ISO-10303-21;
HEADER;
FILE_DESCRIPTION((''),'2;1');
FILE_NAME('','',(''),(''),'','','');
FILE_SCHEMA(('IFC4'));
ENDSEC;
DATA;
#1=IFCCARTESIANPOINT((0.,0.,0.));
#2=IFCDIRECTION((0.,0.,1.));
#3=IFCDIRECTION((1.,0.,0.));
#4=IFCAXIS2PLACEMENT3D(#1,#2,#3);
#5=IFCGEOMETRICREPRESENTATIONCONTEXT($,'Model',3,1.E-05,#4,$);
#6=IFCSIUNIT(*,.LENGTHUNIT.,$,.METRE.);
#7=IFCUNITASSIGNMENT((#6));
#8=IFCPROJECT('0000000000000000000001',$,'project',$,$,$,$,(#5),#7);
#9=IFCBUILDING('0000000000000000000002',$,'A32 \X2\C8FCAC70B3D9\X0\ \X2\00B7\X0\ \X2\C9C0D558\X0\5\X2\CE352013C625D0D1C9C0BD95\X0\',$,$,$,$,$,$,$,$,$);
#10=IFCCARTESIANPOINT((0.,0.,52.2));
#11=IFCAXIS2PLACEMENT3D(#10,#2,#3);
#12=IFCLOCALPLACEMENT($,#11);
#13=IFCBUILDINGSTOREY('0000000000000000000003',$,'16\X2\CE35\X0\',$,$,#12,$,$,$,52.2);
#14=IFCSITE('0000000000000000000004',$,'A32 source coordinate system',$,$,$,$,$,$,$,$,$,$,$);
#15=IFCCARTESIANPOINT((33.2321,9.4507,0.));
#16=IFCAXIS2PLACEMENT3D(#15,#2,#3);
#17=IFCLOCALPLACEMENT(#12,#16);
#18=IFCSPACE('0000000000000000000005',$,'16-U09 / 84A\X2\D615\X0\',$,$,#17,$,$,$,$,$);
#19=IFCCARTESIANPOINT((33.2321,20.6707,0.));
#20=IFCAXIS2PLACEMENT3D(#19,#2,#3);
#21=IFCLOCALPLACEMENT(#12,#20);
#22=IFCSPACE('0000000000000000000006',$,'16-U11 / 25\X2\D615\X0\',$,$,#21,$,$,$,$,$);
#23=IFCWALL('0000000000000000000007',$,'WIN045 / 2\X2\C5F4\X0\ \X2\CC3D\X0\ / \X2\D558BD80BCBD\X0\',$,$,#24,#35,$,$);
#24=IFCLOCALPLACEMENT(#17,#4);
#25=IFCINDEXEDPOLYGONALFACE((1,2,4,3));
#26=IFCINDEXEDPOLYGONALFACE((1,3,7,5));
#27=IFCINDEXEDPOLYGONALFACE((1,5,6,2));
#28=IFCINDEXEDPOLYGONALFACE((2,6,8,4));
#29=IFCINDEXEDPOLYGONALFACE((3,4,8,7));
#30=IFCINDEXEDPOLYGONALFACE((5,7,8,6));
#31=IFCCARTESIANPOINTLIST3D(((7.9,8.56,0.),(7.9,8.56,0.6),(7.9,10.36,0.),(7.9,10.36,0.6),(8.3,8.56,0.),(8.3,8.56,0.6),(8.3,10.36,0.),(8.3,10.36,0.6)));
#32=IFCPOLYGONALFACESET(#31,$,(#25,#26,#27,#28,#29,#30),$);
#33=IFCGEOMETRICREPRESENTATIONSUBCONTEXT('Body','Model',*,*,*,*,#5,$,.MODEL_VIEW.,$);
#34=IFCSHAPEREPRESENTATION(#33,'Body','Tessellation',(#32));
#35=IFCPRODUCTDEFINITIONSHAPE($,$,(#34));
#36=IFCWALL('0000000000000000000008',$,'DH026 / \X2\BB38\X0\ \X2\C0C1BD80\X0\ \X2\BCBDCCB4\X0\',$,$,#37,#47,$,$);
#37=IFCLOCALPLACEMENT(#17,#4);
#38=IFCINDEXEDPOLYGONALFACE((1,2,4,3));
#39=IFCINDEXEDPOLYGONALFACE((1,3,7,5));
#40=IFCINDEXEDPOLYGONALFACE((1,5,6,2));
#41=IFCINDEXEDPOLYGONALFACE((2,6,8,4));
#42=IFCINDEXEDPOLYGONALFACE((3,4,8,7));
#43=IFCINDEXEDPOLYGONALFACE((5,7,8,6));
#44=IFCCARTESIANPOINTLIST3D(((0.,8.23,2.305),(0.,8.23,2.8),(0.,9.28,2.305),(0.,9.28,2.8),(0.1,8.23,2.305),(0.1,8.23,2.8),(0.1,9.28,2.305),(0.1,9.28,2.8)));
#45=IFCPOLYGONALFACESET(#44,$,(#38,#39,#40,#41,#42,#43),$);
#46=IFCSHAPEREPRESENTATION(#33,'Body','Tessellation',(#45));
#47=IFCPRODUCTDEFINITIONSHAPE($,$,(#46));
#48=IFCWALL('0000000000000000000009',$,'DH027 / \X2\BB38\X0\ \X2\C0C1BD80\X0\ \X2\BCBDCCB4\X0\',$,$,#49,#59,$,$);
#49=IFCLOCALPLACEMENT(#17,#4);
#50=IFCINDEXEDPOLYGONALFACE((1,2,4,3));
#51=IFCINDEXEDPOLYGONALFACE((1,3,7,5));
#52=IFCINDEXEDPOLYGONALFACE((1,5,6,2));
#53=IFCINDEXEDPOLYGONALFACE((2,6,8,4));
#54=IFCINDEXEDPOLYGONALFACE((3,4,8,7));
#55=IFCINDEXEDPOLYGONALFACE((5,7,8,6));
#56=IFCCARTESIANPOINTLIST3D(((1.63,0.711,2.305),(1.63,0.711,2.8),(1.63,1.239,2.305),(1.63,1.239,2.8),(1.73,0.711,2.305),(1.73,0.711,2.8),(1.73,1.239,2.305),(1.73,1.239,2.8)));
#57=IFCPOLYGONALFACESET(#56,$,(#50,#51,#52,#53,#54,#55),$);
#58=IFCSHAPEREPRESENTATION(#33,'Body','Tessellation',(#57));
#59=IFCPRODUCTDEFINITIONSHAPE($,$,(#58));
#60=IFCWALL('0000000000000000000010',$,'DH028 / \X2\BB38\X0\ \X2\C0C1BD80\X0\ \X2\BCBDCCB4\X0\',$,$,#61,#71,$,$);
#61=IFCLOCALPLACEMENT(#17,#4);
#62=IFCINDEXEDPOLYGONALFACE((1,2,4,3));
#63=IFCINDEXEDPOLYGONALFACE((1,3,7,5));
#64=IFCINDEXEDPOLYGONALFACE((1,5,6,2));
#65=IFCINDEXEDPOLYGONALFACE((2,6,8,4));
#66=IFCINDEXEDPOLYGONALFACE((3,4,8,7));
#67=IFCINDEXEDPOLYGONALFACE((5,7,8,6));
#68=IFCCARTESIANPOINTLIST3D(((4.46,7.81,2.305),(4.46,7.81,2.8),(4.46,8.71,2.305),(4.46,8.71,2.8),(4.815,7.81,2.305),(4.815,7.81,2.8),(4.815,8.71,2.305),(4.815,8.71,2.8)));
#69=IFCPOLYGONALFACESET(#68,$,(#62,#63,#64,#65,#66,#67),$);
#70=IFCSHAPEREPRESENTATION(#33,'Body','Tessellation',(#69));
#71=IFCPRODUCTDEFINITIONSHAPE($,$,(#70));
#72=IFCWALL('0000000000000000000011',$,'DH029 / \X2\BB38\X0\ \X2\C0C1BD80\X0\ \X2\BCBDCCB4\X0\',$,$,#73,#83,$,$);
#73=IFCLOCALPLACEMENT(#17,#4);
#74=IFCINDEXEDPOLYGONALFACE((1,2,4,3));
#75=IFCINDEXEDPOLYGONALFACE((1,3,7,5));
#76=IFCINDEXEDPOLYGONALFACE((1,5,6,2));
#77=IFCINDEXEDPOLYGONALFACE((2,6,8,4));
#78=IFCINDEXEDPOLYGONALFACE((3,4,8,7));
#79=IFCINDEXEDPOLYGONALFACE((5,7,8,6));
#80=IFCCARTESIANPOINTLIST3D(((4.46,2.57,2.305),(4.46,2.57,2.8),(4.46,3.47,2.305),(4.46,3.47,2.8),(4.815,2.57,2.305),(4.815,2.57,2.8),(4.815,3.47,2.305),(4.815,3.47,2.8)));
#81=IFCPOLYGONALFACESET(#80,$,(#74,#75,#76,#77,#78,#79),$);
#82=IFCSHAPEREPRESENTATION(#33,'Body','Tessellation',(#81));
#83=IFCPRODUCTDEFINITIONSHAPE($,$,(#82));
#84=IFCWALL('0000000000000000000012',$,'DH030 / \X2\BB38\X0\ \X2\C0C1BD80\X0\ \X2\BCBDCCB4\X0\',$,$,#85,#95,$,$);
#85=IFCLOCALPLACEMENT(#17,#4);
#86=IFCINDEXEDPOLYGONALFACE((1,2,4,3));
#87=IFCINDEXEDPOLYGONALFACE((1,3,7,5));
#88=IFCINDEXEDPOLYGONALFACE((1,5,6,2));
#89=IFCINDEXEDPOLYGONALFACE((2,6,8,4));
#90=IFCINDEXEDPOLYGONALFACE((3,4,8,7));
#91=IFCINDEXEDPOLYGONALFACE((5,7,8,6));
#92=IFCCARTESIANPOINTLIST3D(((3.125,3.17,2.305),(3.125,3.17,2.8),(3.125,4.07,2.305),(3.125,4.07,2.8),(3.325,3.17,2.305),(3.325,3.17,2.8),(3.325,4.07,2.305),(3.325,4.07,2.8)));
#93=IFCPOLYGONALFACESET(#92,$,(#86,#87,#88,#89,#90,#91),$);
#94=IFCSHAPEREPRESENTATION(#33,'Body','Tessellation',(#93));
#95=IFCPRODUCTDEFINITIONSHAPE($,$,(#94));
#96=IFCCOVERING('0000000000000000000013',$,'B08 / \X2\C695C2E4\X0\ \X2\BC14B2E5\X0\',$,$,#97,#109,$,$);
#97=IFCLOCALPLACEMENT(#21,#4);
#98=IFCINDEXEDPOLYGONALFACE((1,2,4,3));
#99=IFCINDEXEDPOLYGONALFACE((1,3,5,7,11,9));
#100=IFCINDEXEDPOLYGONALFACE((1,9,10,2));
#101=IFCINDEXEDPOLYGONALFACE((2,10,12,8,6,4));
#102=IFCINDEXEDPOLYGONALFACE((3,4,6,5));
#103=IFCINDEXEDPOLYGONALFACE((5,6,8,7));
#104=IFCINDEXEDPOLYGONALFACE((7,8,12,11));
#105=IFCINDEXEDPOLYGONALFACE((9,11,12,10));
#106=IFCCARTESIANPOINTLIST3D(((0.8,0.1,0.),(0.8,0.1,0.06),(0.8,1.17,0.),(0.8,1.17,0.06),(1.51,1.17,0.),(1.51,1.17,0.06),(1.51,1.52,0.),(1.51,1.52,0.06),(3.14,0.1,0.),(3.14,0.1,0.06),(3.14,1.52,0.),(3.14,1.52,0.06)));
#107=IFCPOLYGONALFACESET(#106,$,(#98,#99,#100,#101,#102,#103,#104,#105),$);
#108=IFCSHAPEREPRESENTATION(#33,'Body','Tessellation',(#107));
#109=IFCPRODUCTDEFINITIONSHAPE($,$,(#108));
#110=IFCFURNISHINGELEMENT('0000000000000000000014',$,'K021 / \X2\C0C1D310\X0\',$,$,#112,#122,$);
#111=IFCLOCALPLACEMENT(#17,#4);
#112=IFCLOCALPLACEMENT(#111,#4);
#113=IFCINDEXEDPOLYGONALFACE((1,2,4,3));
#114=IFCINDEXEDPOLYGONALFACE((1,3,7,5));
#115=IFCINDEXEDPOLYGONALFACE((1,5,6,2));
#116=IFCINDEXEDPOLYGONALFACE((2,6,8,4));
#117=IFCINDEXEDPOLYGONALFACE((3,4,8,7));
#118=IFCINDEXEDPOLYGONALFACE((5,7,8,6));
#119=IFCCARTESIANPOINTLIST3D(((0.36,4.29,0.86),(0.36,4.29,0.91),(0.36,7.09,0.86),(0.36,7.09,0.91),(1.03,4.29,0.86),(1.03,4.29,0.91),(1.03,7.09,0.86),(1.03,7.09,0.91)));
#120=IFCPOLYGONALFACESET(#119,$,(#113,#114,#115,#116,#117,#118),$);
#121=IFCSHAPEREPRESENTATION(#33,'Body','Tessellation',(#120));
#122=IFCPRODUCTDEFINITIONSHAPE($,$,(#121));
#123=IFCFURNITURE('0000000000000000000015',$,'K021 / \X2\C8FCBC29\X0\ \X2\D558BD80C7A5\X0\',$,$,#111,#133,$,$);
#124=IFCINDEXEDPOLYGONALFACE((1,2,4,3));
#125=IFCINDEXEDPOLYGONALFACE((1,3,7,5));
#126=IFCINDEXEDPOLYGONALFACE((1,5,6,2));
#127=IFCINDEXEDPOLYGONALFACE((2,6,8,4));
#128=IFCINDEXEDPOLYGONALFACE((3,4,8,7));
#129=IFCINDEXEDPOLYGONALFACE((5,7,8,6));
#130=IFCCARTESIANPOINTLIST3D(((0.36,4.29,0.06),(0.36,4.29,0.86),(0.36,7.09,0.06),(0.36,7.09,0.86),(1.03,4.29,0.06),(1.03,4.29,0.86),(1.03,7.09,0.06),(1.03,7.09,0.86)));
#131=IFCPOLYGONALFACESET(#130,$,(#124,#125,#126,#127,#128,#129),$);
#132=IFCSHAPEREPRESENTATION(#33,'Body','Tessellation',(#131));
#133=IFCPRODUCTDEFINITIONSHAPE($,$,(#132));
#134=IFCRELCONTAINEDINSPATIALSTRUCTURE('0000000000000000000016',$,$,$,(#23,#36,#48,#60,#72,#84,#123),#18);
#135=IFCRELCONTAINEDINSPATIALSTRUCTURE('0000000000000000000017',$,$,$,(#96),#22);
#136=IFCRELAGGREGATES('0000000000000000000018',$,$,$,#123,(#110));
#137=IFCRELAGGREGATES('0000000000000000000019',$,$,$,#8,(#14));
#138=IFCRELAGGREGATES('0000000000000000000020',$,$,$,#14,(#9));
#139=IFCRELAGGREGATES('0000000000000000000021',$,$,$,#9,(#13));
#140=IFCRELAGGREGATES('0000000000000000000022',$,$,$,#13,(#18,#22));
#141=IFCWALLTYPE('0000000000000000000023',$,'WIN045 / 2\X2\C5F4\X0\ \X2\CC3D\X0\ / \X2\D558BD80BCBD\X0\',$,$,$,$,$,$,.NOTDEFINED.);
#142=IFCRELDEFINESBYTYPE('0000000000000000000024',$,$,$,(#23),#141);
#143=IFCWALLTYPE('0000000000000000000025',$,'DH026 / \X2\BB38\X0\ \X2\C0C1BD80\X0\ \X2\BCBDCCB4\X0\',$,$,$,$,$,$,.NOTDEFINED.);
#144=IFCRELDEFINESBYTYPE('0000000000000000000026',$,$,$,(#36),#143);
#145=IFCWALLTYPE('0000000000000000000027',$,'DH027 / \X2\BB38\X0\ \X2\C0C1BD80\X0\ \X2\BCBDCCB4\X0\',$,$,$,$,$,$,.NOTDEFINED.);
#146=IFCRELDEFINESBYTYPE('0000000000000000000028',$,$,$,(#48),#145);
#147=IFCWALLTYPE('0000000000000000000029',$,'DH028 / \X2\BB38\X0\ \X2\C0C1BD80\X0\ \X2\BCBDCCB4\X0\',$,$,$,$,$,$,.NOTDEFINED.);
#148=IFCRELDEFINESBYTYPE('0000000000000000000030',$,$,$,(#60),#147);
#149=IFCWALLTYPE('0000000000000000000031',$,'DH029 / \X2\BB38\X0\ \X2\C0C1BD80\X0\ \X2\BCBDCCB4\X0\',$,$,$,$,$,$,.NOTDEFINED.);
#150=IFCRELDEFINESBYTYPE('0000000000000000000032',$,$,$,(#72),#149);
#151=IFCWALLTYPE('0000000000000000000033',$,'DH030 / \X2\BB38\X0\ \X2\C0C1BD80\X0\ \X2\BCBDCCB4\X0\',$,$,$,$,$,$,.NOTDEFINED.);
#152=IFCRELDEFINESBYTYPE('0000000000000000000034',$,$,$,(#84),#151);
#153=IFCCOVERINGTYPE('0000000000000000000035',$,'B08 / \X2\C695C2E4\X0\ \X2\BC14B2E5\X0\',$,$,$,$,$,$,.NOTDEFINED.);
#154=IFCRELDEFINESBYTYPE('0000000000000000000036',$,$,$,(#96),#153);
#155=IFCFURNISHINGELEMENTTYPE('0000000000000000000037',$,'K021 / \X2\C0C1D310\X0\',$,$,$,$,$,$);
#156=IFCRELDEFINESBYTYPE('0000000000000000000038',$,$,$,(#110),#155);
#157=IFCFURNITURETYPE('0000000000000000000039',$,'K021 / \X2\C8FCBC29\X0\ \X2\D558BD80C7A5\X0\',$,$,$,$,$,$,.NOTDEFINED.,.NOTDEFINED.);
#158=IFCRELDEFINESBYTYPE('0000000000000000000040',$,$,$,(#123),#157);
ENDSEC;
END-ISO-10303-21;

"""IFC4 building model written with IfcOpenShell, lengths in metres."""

from ifc_helpers import new_model, si_unit, frame, origin, origin_with_axes, place, context, subcontext, project, spatial, polyline, outline, extrude, source, transform, mapped, type_object, type_shapes, element, aggregate, save


model = new_model("IFC4")

# Units and contexts
model_context = context("Model", 3, precision=1e-05, world=origin_with_axes())
body_context = subcontext(model_context, "Body", "Model", "MODEL_VIEW")
ifc_project = project(units=[si_unit("LENGTHUNIT", "METRE")], contexts=[model_context])

# Site, building, storey, space
site = spatial("IfcSite", under=ifc_project, Name="A32 source coordinate system")
building = spatial("IfcBuilding", under=site, Name="A32 주거동 · 지하5층–옥탑지붕")
storey_placement = place(None, frame((0.0, 0.0, 52.2), z_axis=(0.0, 0.0, 1.0), x_axis=(1.0, 0.0, 0.0)))
storey = spatial("IfcBuildingStorey", under=building, at=storey_placement, Name="16층", Elevation=52.2)
space_1_placement = place(storey_placement, frame((33.2321, 9.4507, 0.0), z_axis=(0.0, 0.0, 1.0), x_axis=(1.0, 0.0, 0.0)))
space_1 = spatial("IfcSpace", under=storey, at=space_1_placement, Name="16-U09 / 84A형")

# Walls
wall_type_1 = type_object("IfcWallType", Name="WIN045 / 2열 창 / 하부벽", PredefinedType="NOTDEFINED")
shared_shape_1 = source(origin(), body_context, "Body", "SweptSolid", [
    extrude(outline(polyline([(7.9, 10.36), (8.3, 10.36), (8.3, 8.56), (7.9, 8.56), (7.9, 10.36)])), origin(), (0.0, 0.0, 1.0), 0.6),
])
type_shapes(wall_type_1, [shared_shape_1])
wall_1_placement = place(space_1_placement, origin_with_axes())
element("IfcWall", 1, at=wall_1_placement, inside=space_1, type_object=wall_type_1, Name="WIN045 / 2열 창 / 하부벽", context=body_context, shape_type="MappedRepresentation", body=[
    mapped(shared_shape_1, transform((0.0, 0.0, 0.0), scale=1.0)),
])
wall_type_2 = type_object("IfcWallType", Name="DH026 / 문 상부 벽체", PredefinedType="NOTDEFINED")
shared_shape_2 = source(origin(), body_context, "Body", "SweptSolid", [
    extrude(outline(polyline([(0.1, 9.28), (0.1, 8.23), (0.0, 8.23), (0.0, 9.28), (0.1, 9.28)])), frame((0.0, 0.0, 2.305)), (0.0, 0.0, 1.0), 0.495),
])
type_shapes(wall_type_2, [shared_shape_2])
wall_2_placement = place(space_1_placement, origin_with_axes())
element("IfcWall", 2, at=wall_2_placement, inside=space_1, type_object=wall_type_2, Name="DH026 / 문 상부 벽체", context=body_context, shape_type="MappedRepresentation", body=[
    mapped(shared_shape_2, transform((0.0, 0.0, 0.0), scale=1.0)),
])
wall_type_3 = type_object("IfcWallType", Name="DH027 / 문 상부 벽체", PredefinedType="NOTDEFINED")
shared_shape_3 = source(origin(), body_context, "Body", "SweptSolid", [
    extrude(outline(polyline([(1.63, 1.239), (1.73, 1.239), (1.73, 0.711), (1.63, 0.711), (1.63, 1.239)])), frame((0.0, 0.0, 2.305)), (0.0, 0.0, 1.0), 0.495),
])
type_shapes(wall_type_3, [shared_shape_3])
wall_3_placement = place(space_1_placement, origin_with_axes())
element("IfcWall", 3, at=wall_3_placement, inside=space_1, type_object=wall_type_3, Name="DH027 / 문 상부 벽체", context=body_context, shape_type="MappedRepresentation", body=[
    mapped(shared_shape_3, transform((0.0, 0.0, 0.0), scale=1.0)),
])
wall_type_4 = type_object("IfcWallType", Name="DH028 / 문 상부 벽체", PredefinedType="NOTDEFINED")
shared_shape_4 = source(origin(), body_context, "Body", "SweptSolid", [
    extrude(outline(polyline([(4.815, 8.71), (4.815, 7.81), (4.46, 7.81), (4.46, 8.71), (4.815, 8.71)])), frame((0.0, 0.0, 2.305)), (0.0, 0.0, 1.0), 0.495),
])
type_shapes(wall_type_4, [shared_shape_4])
wall_4_placement = place(space_1_placement, origin_with_axes())
element("IfcWall", 4, at=wall_4_placement, inside=space_1, type_object=wall_type_4, Name="DH028 / 문 상부 벽체", context=body_context, shape_type="MappedRepresentation", body=[
    mapped(shared_shape_4, transform((0.0, 0.0, 0.0), scale=1.0)),
])
wall_type_5 = type_object("IfcWallType", Name="DH029 / 문 상부 벽체", PredefinedType="NOTDEFINED")
shared_shape_5 = source(origin(), body_context, "Body", "SweptSolid", [
    extrude(outline(polyline([(4.815, 3.47), (4.815, 2.57), (4.46, 2.57), (4.46, 3.47), (4.815, 3.47)])), frame((0.0, 0.0, 2.305)), (0.0, 0.0, 1.0), 0.495),
])
type_shapes(wall_type_5, [shared_shape_5])
wall_5_placement = place(space_1_placement, origin_with_axes())
element("IfcWall", 5, at=wall_5_placement, inside=space_1, type_object=wall_type_5, Name="DH029 / 문 상부 벽체", context=body_context, shape_type="MappedRepresentation", body=[
    mapped(shared_shape_5, transform((0.0, 0.0, 0.0), scale=1.0)),
])
wall_type_6 = type_object("IfcWallType", Name="DH030 / 문 상부 벽체", PredefinedType="NOTDEFINED")
shared_shape_6 = source(origin(), body_context, "Body", "SweptSolid", [
    extrude(outline(polyline([(3.325, 4.07), (3.325, 3.17), (3.125, 3.17), (3.125, 4.07), (3.325, 4.07)])), frame((0.0, 0.0, 2.305)), (0.0, 0.0, 1.0), 0.495),
])
type_shapes(wall_type_6, [shared_shape_6])
wall_6_placement = place(space_1_placement, origin_with_axes())
element("IfcWall", 6, at=wall_6_placement, inside=space_1, type_object=wall_type_6, Name="DH030 / 문 상부 벽체", context=body_context, shape_type="MappedRepresentation", body=[
    mapped(shared_shape_6, transform((0.0, 0.0, 0.0), scale=1.0)),
])

# Shared definitions
space_2_placement = place(storey_placement, frame((33.2321, 20.6707, 0.0), z_axis=(0.0, 0.0, 1.0), x_axis=(1.0, 0.0, 0.0)))
space_2 = spatial("IfcSpace", under=storey, at=space_2_placement, Name="16-U11 / 25형")

# Covering
covering_type_1 = type_object("IfcCoveringType", Name="B08 / 욕실 바닥", PredefinedType="NOTDEFINED")
shared_shape_7 = source(origin(), body_context, "Body", "SweptSolid", [
    extrude(outline(polyline([(3.14, 0.1), (0.8, 0.1), (0.8, 1.17), (1.51, 1.17), (1.51, 1.52), (3.14, 1.52), (3.14, 0.1)])), origin(), (0.0, 0.0, 1.0), 0.06),
])
type_shapes(covering_type_1, [shared_shape_7])
covering_1_placement = place(space_2_placement, origin_with_axes())
element("IfcCovering", 7, at=covering_1_placement, inside=space_2, type_object=covering_type_1, Name="B08 / 욕실 바닥", context=body_context, shape_type="MappedRepresentation", body=[
    mapped(shared_shape_7, transform((0.0, 0.0, 0.0), scale=1.0)),
])

# Furnishing element
furnishing_element_type = type_object("IfcFurnishingElementType", Name="K021 / 상판")
shared_shape_8 = source(origin(), body_context, "Body", "SweptSolid", [
    extrude(outline(polyline([(0.36, 7.09), (1.03, 7.09), (1.03, 4.29), (0.36, 4.29), (0.36, 7.09)])), frame((0.0, 0.0, 0.86)), (0.0, 0.0, 1.0), 0.05),
])
type_shapes(furnishing_element_type, [shared_shape_8])
furniture_placement = place(space_1_placement, origin_with_axes())
furnishing_placement = place(furniture_placement, origin_with_axes())
furnishing = element("IfcFurnishingElement", 8, at=furnishing_placement, type_object=furnishing_element_type, Name="K021 / 상판", context=body_context, shape_type="MappedRepresentation", body=[
    mapped(shared_shape_8, transform((0.0, 0.0, 0.0), scale=1.0)),
])

# Furniture
furniture_type = type_object("IfcFurnitureType", Name="K021 / 주방 하부장", AssemblyPlace="NOTDEFINED", PredefinedType="NOTDEFINED")
shared_shape_9 = source(origin(), body_context, "Body", "SweptSolid", [
    extrude(outline(polyline([(0.36, 4.29), (0.36, 7.09), (1.03, 7.09), (1.03, 4.29), (0.36, 4.29)])), frame((0.0, 0.0, 0.06)), (0.0, 0.0, 1.0), 0.8),
])
type_shapes(furniture_type, [shared_shape_9])
furniture = element("IfcFurniture", 9, at=furniture_placement, inside=space_1, type_object=furniture_type, Name="K021 / 주방 하부장", context=body_context, shape_type="MappedRepresentation", body=[
    mapped(shared_shape_9, transform((0.0, 0.0, 0.0), scale=1.0)),
])
aggregate(furniture, [furnishing])

save(model, "model.ifc")
